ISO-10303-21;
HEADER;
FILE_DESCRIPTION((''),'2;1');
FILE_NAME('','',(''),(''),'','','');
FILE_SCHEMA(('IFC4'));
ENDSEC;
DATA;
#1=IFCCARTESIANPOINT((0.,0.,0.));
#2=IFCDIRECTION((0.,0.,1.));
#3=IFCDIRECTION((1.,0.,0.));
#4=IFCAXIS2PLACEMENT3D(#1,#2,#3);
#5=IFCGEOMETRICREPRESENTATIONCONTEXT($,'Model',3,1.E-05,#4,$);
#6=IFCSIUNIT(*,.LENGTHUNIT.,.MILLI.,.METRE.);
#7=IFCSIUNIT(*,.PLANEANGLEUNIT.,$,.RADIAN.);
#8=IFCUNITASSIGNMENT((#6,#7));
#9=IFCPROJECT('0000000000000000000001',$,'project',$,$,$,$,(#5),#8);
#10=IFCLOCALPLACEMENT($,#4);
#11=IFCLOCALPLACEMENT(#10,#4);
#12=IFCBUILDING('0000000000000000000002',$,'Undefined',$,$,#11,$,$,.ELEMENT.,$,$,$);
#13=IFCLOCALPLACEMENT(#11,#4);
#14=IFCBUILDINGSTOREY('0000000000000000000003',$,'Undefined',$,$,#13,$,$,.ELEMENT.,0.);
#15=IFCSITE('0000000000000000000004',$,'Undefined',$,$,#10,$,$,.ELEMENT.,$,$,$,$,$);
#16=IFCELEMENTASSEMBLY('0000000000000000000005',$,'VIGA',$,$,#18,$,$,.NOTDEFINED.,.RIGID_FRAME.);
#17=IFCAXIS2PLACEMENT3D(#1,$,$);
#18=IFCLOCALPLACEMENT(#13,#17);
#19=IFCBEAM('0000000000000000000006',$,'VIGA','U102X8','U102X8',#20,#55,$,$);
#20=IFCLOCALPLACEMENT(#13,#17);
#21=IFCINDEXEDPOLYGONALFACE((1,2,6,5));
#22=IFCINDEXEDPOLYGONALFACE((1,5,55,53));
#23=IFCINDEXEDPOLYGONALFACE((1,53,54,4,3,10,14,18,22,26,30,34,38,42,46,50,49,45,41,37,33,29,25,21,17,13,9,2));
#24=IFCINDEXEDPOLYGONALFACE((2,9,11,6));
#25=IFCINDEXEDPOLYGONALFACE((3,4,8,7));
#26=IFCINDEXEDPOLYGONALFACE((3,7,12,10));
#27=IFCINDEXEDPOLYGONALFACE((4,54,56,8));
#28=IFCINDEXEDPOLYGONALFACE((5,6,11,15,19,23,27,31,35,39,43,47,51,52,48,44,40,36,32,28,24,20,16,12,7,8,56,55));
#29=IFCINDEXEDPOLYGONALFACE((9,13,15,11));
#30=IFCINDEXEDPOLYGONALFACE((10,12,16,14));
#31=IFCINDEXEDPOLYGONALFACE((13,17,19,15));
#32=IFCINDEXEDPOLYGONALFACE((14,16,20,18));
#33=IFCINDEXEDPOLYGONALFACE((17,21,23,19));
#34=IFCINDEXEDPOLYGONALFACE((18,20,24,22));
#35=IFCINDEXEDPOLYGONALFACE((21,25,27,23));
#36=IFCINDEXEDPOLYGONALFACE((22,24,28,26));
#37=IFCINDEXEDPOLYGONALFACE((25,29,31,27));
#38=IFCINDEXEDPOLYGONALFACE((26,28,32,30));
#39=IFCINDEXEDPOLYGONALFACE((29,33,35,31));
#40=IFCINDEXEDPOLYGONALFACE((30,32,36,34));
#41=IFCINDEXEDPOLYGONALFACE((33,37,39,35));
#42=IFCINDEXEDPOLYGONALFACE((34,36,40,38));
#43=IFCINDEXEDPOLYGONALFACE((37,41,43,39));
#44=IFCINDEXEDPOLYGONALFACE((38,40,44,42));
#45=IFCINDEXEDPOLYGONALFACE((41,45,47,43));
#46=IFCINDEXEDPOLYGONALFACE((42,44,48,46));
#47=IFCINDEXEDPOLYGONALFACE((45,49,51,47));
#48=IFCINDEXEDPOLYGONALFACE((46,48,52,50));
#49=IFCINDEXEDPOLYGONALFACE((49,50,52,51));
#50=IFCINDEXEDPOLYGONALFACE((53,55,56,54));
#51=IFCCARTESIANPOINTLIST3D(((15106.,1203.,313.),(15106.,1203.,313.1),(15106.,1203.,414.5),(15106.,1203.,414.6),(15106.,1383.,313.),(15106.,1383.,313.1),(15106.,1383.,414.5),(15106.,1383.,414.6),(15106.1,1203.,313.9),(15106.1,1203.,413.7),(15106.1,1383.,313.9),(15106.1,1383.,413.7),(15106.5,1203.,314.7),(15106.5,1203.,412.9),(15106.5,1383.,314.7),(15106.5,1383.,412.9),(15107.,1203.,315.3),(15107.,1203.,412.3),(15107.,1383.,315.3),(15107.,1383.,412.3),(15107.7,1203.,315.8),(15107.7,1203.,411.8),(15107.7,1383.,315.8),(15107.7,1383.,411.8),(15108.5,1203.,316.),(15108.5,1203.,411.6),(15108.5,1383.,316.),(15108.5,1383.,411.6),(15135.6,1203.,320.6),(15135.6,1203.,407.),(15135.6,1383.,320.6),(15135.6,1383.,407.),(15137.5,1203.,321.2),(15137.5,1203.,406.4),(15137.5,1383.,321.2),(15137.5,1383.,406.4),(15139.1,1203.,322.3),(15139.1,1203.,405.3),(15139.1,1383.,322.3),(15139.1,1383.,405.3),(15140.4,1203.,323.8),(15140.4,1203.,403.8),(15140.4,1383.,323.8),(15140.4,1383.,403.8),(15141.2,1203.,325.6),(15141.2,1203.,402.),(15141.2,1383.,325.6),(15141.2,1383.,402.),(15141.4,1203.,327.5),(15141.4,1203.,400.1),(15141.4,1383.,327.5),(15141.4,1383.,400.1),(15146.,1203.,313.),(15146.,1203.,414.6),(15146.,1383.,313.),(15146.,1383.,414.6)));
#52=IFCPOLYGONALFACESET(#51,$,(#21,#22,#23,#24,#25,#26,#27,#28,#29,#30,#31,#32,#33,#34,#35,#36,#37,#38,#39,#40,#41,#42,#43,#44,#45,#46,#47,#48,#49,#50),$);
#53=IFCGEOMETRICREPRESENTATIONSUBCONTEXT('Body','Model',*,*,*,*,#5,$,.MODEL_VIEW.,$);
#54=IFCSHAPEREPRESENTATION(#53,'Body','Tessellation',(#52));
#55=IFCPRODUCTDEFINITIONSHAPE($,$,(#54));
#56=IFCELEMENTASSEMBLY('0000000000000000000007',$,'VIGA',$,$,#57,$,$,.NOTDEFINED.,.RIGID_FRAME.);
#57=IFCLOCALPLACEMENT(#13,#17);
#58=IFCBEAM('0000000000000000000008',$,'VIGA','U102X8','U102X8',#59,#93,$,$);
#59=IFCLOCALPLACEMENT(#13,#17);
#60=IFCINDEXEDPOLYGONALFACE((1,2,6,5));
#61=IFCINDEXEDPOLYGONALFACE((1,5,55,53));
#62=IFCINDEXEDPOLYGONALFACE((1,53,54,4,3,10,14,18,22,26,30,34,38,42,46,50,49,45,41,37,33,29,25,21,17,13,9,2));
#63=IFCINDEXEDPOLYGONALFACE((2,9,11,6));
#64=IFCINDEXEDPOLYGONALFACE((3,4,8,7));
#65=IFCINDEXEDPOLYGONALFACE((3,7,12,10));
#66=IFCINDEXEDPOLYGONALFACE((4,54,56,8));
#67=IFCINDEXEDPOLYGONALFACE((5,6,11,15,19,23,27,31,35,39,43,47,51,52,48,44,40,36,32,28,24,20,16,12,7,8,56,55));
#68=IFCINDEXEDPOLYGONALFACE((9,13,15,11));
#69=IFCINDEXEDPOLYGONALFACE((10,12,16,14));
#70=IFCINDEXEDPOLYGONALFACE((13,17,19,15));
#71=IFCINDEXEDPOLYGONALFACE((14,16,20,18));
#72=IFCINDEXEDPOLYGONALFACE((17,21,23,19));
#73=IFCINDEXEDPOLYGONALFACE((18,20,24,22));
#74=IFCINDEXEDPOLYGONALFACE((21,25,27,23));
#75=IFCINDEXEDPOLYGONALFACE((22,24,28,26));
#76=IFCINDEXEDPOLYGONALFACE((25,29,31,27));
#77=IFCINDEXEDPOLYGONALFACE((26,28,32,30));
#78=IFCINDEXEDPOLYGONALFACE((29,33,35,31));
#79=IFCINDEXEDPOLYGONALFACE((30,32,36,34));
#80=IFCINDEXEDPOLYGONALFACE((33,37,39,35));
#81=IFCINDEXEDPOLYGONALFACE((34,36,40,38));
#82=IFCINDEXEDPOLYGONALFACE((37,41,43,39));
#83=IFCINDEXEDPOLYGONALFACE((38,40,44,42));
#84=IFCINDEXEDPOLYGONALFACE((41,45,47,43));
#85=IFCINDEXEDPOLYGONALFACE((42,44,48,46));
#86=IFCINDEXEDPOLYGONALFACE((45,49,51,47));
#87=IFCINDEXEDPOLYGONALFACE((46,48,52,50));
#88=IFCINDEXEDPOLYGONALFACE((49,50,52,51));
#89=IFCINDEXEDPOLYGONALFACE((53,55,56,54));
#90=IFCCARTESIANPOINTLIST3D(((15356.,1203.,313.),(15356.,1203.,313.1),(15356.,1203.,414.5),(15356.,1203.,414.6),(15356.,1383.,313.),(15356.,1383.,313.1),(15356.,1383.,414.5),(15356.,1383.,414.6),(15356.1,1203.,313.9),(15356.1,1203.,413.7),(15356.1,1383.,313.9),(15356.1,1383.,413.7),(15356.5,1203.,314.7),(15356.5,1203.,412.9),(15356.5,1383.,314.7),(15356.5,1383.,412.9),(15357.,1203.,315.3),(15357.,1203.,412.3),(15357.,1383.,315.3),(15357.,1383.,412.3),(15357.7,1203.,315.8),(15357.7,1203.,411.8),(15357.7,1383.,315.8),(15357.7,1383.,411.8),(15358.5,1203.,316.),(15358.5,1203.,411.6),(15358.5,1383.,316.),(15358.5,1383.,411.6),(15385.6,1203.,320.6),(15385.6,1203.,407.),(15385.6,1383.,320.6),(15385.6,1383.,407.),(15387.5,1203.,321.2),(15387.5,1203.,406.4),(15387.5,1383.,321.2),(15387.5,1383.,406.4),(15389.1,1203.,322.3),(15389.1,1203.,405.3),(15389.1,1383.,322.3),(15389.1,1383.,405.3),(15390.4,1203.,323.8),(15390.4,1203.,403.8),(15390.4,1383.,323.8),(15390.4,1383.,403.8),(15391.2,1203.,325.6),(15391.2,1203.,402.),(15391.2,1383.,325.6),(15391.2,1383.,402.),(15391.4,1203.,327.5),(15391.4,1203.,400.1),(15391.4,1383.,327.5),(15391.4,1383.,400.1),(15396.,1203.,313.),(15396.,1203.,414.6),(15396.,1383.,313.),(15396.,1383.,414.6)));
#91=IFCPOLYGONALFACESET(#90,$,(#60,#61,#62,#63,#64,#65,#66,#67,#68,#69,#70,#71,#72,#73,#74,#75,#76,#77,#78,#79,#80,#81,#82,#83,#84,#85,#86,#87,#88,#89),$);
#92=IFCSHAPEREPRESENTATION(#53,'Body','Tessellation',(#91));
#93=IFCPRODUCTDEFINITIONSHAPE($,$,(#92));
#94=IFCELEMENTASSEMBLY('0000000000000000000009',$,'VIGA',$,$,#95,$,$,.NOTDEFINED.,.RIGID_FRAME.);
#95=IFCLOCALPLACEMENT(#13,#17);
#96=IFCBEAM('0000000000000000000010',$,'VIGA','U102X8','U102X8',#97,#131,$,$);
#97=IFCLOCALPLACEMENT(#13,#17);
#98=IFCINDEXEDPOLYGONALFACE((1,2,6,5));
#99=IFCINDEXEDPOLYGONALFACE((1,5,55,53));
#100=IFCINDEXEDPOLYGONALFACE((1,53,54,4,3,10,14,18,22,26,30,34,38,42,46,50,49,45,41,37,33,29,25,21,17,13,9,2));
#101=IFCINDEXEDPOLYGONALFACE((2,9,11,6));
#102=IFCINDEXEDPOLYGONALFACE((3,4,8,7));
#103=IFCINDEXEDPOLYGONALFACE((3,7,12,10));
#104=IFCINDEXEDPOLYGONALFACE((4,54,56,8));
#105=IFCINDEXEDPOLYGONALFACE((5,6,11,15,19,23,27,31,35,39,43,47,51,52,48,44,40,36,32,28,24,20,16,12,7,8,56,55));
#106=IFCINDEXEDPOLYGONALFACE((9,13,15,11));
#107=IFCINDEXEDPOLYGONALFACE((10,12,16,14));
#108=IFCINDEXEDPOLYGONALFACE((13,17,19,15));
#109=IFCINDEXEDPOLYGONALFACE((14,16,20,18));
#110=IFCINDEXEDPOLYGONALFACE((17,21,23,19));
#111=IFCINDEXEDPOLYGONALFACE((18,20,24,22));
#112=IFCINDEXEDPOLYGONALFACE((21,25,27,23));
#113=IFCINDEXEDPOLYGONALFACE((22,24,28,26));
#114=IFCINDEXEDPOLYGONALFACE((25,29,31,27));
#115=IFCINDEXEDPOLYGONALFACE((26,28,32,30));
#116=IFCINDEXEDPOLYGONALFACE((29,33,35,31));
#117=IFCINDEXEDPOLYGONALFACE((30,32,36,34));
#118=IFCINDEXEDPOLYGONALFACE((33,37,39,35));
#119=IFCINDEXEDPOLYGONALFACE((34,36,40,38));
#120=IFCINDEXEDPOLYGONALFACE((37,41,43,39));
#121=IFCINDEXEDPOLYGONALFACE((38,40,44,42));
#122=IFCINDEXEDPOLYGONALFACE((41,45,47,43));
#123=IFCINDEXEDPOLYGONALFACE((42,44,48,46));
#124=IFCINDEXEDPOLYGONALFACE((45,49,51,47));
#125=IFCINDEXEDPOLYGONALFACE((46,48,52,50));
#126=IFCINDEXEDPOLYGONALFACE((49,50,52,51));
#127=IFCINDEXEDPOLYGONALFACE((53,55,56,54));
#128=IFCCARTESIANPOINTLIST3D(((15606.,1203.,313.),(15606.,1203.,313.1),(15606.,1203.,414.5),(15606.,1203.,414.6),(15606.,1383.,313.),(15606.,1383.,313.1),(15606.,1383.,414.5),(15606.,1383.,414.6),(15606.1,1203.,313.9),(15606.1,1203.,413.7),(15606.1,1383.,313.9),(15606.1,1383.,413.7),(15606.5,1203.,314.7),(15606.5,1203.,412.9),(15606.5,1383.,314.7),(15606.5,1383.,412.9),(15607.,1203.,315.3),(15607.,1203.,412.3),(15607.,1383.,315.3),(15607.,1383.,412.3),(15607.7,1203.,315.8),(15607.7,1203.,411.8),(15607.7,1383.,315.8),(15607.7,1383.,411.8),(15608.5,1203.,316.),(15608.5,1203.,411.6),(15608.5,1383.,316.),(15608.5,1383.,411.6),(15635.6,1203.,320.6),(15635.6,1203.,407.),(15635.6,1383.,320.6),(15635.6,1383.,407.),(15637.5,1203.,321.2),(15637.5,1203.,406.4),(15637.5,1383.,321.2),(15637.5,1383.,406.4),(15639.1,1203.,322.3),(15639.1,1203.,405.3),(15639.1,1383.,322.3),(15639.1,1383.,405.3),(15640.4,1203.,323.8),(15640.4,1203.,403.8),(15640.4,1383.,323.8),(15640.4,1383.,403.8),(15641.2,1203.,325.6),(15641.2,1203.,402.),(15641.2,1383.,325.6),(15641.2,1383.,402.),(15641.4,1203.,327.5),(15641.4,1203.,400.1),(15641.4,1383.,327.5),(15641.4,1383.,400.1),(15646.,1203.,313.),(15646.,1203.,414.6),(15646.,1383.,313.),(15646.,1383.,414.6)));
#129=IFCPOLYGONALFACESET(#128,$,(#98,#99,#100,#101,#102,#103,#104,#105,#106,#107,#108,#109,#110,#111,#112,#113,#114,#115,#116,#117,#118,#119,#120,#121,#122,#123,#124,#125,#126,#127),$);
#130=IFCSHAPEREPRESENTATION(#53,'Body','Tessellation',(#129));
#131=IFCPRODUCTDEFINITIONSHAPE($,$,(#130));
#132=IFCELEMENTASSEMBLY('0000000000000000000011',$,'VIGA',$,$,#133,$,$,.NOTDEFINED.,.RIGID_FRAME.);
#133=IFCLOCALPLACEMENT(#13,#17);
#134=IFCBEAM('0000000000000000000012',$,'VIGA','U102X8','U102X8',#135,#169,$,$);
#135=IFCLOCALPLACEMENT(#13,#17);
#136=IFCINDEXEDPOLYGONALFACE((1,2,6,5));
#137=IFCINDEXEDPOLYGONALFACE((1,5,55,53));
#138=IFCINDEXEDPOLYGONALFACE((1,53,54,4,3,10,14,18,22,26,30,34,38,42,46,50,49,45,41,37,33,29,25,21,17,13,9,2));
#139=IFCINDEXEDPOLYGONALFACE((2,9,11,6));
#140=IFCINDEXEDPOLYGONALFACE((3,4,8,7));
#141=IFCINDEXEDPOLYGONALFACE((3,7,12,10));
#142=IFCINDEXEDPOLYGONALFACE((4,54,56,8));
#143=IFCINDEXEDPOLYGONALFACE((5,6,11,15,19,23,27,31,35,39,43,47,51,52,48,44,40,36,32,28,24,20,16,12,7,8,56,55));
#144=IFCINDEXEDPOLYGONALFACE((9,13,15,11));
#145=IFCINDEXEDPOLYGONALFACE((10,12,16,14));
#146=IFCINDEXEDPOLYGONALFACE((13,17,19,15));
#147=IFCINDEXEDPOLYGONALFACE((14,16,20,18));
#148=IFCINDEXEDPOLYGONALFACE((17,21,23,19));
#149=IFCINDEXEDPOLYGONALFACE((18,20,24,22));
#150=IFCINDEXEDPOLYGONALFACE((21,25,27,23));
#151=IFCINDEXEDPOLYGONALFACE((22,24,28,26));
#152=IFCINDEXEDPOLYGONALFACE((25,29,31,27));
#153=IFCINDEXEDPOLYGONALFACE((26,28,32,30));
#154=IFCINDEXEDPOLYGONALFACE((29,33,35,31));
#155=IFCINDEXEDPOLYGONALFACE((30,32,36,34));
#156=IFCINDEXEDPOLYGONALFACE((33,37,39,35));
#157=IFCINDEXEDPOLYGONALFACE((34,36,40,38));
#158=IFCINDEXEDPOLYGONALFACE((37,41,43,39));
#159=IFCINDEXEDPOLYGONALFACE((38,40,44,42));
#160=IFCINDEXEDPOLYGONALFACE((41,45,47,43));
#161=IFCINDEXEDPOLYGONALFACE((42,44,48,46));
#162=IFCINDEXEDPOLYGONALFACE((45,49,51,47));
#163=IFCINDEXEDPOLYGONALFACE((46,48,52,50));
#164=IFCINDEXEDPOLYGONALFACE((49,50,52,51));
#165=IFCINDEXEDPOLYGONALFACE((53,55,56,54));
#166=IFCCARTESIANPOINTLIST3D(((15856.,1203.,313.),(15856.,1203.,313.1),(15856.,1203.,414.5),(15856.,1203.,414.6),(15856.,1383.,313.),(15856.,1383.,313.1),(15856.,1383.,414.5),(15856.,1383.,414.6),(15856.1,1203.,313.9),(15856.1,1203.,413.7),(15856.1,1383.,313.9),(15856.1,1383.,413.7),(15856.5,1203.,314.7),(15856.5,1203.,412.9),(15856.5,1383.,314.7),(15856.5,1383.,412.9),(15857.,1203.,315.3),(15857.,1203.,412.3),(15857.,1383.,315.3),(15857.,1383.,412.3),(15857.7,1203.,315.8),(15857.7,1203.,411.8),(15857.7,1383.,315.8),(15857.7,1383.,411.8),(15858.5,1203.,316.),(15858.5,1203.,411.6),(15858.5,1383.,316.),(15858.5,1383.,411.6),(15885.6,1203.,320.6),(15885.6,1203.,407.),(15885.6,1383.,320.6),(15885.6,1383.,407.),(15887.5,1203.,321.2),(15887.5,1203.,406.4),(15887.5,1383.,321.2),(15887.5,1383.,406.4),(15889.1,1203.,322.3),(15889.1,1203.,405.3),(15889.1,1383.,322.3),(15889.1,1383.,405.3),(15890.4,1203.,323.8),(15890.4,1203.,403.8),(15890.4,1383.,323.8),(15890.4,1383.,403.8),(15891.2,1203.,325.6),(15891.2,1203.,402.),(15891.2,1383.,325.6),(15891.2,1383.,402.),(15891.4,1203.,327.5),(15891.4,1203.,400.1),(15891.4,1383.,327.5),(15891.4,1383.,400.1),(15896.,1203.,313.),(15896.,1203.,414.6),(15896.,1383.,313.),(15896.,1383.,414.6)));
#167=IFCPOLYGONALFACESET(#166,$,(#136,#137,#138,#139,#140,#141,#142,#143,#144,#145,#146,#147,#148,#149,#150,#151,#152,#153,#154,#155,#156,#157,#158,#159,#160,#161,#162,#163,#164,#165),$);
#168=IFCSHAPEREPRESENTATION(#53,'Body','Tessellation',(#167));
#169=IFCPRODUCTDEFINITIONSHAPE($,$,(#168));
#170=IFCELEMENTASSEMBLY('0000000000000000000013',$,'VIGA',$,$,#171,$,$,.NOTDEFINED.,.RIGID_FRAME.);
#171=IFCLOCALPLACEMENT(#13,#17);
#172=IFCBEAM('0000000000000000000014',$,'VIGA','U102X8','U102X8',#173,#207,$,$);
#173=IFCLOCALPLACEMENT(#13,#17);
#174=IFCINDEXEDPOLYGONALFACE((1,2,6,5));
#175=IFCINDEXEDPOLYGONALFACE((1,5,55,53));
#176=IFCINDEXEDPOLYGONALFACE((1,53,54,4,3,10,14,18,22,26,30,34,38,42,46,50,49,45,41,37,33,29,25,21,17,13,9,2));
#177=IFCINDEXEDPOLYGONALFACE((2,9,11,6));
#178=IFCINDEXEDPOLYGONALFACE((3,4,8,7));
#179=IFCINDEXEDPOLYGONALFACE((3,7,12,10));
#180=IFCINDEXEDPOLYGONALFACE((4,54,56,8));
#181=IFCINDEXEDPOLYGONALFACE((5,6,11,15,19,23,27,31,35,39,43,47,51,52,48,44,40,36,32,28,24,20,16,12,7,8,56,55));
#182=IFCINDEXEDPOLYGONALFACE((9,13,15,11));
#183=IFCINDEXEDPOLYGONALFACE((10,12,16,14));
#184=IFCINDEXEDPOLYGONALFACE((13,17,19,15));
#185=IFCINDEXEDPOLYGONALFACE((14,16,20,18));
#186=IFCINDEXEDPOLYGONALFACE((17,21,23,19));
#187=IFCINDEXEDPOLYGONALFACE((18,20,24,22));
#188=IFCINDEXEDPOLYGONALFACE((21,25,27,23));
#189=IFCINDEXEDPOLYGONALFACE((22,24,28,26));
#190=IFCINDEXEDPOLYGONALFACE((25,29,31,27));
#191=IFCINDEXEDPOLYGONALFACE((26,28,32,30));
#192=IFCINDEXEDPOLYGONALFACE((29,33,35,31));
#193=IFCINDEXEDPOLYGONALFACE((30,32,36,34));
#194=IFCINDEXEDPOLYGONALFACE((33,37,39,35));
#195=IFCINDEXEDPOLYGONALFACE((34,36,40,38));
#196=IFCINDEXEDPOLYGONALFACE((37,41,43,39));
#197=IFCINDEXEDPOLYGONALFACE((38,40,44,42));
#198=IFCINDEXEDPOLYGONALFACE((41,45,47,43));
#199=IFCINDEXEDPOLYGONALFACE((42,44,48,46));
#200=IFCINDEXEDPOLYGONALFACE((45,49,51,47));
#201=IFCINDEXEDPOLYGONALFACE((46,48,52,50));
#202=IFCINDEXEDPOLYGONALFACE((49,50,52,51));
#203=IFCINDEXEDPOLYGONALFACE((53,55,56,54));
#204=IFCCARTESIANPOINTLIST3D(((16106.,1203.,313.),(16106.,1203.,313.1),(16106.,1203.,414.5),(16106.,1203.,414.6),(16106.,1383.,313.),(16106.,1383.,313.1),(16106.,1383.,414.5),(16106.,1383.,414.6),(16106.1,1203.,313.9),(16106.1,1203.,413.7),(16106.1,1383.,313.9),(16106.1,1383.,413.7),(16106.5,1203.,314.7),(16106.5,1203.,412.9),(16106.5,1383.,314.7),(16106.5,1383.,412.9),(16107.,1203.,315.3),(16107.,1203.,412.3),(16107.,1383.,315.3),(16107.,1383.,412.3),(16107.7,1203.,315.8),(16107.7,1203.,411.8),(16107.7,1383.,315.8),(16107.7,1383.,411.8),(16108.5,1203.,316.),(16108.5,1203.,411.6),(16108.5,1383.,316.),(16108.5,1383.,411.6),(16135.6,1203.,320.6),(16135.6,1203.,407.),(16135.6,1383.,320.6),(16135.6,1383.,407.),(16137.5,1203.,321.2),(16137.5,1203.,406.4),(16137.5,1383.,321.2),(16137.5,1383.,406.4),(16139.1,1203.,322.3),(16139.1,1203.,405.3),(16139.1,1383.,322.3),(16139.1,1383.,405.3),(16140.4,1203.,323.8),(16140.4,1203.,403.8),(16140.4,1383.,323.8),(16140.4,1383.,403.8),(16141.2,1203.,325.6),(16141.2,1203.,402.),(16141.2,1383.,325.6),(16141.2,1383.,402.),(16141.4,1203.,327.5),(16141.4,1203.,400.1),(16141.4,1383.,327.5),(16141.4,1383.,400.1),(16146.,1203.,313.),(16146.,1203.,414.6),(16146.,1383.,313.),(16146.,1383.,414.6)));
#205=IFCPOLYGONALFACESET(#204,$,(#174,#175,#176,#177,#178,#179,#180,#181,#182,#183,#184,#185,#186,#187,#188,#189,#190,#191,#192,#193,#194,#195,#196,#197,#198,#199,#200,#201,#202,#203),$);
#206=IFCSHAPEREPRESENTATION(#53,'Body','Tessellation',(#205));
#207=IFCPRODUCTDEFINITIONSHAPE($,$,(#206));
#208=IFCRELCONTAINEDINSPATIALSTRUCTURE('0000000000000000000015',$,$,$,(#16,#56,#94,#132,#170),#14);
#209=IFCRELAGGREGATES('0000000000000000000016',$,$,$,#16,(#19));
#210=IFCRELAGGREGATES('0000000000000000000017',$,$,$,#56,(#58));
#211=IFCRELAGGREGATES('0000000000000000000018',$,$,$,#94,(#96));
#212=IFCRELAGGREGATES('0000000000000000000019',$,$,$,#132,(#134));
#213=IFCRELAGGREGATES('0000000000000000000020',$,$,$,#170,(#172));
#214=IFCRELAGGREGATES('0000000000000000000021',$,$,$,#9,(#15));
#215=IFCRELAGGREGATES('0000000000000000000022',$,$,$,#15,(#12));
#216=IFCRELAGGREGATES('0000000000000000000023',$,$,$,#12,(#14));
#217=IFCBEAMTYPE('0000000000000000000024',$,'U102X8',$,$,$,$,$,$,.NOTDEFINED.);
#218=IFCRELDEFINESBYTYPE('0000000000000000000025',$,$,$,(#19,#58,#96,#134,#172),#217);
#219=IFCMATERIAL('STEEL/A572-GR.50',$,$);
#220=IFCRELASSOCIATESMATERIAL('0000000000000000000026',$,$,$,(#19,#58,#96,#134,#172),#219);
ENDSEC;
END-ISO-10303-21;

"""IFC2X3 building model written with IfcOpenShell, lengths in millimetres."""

from ifc_helpers import new_model, si_unit, frame, origin_with_axes, origin_2d_with_axis, place, context, subcontext, project, spatial, u_section, extrude, material, type_object, element, aggregate, save


model = new_model("IFC2X3")

# Units and contexts
model_context = context("Model", 3, precision=1e-05, world=origin_with_axes())
body_context = subcontext(model_context, "Body", "Model", "MODEL_VIEW")
ifc_project = project(units=[si_unit("LENGTHUNIT", "METRE", prefix="MILLI"), si_unit("PLANEANGLEUNIT", "RADIAN")], contexts=[model_context])

# Site, building, storey
site_placement = place(None, origin_with_axes())
site = spatial("IfcSite", under=ifc_project, at=site_placement, Name="Undefined", CompositionType="ELEMENT")
building_placement = place(site_placement, origin_with_axes())
building = spatial("IfcBuilding", under=site, at=building_placement, Name="Undefined", CompositionType="ELEMENT")
storey_placement = place(building_placement, origin_with_axes())
storey = spatial("IfcBuildingStorey", under=building, at=storey_placement, Name="Undefined", CompositionType="ELEMENT", Elevation=0.0)

# Element assemblies, beams
ifc_material = material(Name="STEEL/A572-GR.50")
beam_type = type_object("IfcBeamType", Name="U102X8", PredefinedType="NOTDEFINED")
assembly_1_placement = place(storey_placement, origin_with_axes())
assembly_1 = element("IfcElementAssembly", 1, at=assembly_1_placement, inside=storey, Name="VIGA", AssemblyPlace="NOTDEFINED", PredefinedType="RIGID_FRAME")
beam_1_placement = place(assembly_1_placement, frame((15126.0, 1383.0, 363.8), z_axis=(0.0, 0.0, 1.0), x_axis=(0.0, -1.0, 0.0)))
beam_1 = element("IfcBeam", 2, at=beam_1_placement, type_object=beam_type, material=ifc_material, Name="VIGA", Description="U102X8", ObjectType="U102X8", context=body_context, shape_type="SweptSolid", body=[
    extrude(u_section(Depth=101.6, FlangeWidth=40.0, WebThickness=4.6, FlangeThickness=6.0, FilletRadius=7.0, EdgeRadius=3.0, FlangeSlope=0.16839, at=origin_2d_with_axis()), frame((180.0, 0.0, 0.0), z_axis=(-1.0, 0.0, 0.0), x_axis=(0.0, -1.0, 0.0)), (0.0, 0.0, 1.0), 180.0),
])
aggregate(assembly_1, [beam_1])
assembly_2_placement = place(storey_placement, origin_with_axes())
assembly_2 = element("IfcElementAssembly", 3, at=assembly_2_placement, inside=storey, Name="VIGA", AssemblyPlace="NOTDEFINED", PredefinedType="RIGID_FRAME")
beam_2_placement = place(assembly_2_placement, frame((15376.0, 1383.0, 363.8), z_axis=(0.0, 0.0, 1.0), x_axis=(0.0, -1.0, 0.0)))
beam_2 = element("IfcBeam", 4, at=beam_2_placement, type_object=beam_type, material=ifc_material, Name="VIGA", Description="U102X8", ObjectType="U102X8", context=body_context, shape_type="SweptSolid", body=[
    extrude(u_section(Depth=101.6, FlangeWidth=40.0, WebThickness=4.6, FlangeThickness=6.0, FilletRadius=7.0, EdgeRadius=3.0, FlangeSlope=0.16839, at=origin_2d_with_axis()), frame((180.0, 0.0, 0.0), z_axis=(-1.0, 0.0, 0.0), x_axis=(0.0, -1.0, 0.0)), (0.0, 0.0, 1.0), 180.0),
])
aggregate(assembly_2, [beam_2])
assembly_3_placement = place(storey_placement, origin_with_axes())
assembly_3 = element("IfcElementAssembly", 5, at=assembly_3_placement, inside=storey, Name="VIGA", AssemblyPlace="NOTDEFINED", PredefinedType="RIGID_FRAME")
beam_3_placement = place(assembly_3_placement, frame((15626.0, 1383.0, 363.8), z_axis=(0.0, 0.0, 1.0), x_axis=(0.0, -1.0, 0.0)))
beam_3 = element("IfcBeam", 6, at=beam_3_placement, type_object=beam_type, material=ifc_material, Name="VIGA", Description="U102X8", ObjectType="U102X8", context=body_context, shape_type="SweptSolid", body=[
    extrude(u_section(Depth=101.6, FlangeWidth=40.0, WebThickness=4.6, FlangeThickness=6.0, FilletRadius=7.0, EdgeRadius=3.0, FlangeSlope=0.16839, at=origin_2d_with_axis()), frame((180.0, 0.0, 0.0), z_axis=(-1.0, 0.0, 0.0), x_axis=(0.0, -1.0, 0.0)), (0.0, 0.0, 1.0), 180.0),
])
aggregate(assembly_3, [beam_3])
assembly_4_placement = place(storey_placement, origin_with_axes())
assembly_4 = element("IfcElementAssembly", 7, at=assembly_4_placement, inside=storey, Name="VIGA", AssemblyPlace="NOTDEFINED", PredefinedType="RIGID_FRAME")
beam_4_placement = place(assembly_4_placement, frame((15876.0, 1383.0, 363.8), z_axis=(0.0, 0.0, 1.0), x_axis=(0.0, -1.0, 0.0)))
beam_4 = element("IfcBeam", 8, at=beam_4_placement, type_object=beam_type, material=ifc_material, Name="VIGA", Description="U102X8", ObjectType="U102X8", context=body_context, shape_type="SweptSolid", body=[
    extrude(u_section(Depth=101.6, FlangeWidth=40.0, WebThickness=4.6, FlangeThickness=6.0, FilletRadius=7.0, EdgeRadius=3.0, FlangeSlope=0.16839, at=origin_2d_with_axis()), frame((180.0, 0.0, 0.0), z_axis=(-1.0, 0.0, 0.0), x_axis=(0.0, -1.0, 0.0)), (0.0, 0.0, 1.0), 180.0),
])
aggregate(assembly_4, [beam_4])
assembly_5_placement = place(storey_placement, origin_with_axes())
assembly_5 = element("IfcElementAssembly", 9, at=assembly_5_placement, inside=storey, Name="VIGA", AssemblyPlace="NOTDEFINED", PredefinedType="RIGID_FRAME")
beam_5_placement = place(assembly_5_placement, frame((16126.0, 1383.0, 363.8), z_axis=(0.0, 0.0, 1.0), x_axis=(0.0, -1.0, 0.0)))
beam_5 = element("IfcBeam", 10, at=beam_5_placement, type_object=beam_type, material=ifc_material, Name="VIGA", Description="U102X8", ObjectType="U102X8", context=body_context, shape_type="SweptSolid", body=[
    extrude(u_section(Depth=101.6, FlangeWidth=40.0, WebThickness=4.6, FlangeThickness=6.0, FilletRadius=7.0, EdgeRadius=3.0, FlangeSlope=0.16839, at=origin_2d_with_axis()), frame((180.0, 0.0, 0.0), z_axis=(-1.0, 0.0, 0.0), x_axis=(0.0, -1.0, 0.0)), (0.0, 0.0, 1.0), 180.0),
])
aggregate(assembly_5, [beam_5])

save(model, "model.ifc")
